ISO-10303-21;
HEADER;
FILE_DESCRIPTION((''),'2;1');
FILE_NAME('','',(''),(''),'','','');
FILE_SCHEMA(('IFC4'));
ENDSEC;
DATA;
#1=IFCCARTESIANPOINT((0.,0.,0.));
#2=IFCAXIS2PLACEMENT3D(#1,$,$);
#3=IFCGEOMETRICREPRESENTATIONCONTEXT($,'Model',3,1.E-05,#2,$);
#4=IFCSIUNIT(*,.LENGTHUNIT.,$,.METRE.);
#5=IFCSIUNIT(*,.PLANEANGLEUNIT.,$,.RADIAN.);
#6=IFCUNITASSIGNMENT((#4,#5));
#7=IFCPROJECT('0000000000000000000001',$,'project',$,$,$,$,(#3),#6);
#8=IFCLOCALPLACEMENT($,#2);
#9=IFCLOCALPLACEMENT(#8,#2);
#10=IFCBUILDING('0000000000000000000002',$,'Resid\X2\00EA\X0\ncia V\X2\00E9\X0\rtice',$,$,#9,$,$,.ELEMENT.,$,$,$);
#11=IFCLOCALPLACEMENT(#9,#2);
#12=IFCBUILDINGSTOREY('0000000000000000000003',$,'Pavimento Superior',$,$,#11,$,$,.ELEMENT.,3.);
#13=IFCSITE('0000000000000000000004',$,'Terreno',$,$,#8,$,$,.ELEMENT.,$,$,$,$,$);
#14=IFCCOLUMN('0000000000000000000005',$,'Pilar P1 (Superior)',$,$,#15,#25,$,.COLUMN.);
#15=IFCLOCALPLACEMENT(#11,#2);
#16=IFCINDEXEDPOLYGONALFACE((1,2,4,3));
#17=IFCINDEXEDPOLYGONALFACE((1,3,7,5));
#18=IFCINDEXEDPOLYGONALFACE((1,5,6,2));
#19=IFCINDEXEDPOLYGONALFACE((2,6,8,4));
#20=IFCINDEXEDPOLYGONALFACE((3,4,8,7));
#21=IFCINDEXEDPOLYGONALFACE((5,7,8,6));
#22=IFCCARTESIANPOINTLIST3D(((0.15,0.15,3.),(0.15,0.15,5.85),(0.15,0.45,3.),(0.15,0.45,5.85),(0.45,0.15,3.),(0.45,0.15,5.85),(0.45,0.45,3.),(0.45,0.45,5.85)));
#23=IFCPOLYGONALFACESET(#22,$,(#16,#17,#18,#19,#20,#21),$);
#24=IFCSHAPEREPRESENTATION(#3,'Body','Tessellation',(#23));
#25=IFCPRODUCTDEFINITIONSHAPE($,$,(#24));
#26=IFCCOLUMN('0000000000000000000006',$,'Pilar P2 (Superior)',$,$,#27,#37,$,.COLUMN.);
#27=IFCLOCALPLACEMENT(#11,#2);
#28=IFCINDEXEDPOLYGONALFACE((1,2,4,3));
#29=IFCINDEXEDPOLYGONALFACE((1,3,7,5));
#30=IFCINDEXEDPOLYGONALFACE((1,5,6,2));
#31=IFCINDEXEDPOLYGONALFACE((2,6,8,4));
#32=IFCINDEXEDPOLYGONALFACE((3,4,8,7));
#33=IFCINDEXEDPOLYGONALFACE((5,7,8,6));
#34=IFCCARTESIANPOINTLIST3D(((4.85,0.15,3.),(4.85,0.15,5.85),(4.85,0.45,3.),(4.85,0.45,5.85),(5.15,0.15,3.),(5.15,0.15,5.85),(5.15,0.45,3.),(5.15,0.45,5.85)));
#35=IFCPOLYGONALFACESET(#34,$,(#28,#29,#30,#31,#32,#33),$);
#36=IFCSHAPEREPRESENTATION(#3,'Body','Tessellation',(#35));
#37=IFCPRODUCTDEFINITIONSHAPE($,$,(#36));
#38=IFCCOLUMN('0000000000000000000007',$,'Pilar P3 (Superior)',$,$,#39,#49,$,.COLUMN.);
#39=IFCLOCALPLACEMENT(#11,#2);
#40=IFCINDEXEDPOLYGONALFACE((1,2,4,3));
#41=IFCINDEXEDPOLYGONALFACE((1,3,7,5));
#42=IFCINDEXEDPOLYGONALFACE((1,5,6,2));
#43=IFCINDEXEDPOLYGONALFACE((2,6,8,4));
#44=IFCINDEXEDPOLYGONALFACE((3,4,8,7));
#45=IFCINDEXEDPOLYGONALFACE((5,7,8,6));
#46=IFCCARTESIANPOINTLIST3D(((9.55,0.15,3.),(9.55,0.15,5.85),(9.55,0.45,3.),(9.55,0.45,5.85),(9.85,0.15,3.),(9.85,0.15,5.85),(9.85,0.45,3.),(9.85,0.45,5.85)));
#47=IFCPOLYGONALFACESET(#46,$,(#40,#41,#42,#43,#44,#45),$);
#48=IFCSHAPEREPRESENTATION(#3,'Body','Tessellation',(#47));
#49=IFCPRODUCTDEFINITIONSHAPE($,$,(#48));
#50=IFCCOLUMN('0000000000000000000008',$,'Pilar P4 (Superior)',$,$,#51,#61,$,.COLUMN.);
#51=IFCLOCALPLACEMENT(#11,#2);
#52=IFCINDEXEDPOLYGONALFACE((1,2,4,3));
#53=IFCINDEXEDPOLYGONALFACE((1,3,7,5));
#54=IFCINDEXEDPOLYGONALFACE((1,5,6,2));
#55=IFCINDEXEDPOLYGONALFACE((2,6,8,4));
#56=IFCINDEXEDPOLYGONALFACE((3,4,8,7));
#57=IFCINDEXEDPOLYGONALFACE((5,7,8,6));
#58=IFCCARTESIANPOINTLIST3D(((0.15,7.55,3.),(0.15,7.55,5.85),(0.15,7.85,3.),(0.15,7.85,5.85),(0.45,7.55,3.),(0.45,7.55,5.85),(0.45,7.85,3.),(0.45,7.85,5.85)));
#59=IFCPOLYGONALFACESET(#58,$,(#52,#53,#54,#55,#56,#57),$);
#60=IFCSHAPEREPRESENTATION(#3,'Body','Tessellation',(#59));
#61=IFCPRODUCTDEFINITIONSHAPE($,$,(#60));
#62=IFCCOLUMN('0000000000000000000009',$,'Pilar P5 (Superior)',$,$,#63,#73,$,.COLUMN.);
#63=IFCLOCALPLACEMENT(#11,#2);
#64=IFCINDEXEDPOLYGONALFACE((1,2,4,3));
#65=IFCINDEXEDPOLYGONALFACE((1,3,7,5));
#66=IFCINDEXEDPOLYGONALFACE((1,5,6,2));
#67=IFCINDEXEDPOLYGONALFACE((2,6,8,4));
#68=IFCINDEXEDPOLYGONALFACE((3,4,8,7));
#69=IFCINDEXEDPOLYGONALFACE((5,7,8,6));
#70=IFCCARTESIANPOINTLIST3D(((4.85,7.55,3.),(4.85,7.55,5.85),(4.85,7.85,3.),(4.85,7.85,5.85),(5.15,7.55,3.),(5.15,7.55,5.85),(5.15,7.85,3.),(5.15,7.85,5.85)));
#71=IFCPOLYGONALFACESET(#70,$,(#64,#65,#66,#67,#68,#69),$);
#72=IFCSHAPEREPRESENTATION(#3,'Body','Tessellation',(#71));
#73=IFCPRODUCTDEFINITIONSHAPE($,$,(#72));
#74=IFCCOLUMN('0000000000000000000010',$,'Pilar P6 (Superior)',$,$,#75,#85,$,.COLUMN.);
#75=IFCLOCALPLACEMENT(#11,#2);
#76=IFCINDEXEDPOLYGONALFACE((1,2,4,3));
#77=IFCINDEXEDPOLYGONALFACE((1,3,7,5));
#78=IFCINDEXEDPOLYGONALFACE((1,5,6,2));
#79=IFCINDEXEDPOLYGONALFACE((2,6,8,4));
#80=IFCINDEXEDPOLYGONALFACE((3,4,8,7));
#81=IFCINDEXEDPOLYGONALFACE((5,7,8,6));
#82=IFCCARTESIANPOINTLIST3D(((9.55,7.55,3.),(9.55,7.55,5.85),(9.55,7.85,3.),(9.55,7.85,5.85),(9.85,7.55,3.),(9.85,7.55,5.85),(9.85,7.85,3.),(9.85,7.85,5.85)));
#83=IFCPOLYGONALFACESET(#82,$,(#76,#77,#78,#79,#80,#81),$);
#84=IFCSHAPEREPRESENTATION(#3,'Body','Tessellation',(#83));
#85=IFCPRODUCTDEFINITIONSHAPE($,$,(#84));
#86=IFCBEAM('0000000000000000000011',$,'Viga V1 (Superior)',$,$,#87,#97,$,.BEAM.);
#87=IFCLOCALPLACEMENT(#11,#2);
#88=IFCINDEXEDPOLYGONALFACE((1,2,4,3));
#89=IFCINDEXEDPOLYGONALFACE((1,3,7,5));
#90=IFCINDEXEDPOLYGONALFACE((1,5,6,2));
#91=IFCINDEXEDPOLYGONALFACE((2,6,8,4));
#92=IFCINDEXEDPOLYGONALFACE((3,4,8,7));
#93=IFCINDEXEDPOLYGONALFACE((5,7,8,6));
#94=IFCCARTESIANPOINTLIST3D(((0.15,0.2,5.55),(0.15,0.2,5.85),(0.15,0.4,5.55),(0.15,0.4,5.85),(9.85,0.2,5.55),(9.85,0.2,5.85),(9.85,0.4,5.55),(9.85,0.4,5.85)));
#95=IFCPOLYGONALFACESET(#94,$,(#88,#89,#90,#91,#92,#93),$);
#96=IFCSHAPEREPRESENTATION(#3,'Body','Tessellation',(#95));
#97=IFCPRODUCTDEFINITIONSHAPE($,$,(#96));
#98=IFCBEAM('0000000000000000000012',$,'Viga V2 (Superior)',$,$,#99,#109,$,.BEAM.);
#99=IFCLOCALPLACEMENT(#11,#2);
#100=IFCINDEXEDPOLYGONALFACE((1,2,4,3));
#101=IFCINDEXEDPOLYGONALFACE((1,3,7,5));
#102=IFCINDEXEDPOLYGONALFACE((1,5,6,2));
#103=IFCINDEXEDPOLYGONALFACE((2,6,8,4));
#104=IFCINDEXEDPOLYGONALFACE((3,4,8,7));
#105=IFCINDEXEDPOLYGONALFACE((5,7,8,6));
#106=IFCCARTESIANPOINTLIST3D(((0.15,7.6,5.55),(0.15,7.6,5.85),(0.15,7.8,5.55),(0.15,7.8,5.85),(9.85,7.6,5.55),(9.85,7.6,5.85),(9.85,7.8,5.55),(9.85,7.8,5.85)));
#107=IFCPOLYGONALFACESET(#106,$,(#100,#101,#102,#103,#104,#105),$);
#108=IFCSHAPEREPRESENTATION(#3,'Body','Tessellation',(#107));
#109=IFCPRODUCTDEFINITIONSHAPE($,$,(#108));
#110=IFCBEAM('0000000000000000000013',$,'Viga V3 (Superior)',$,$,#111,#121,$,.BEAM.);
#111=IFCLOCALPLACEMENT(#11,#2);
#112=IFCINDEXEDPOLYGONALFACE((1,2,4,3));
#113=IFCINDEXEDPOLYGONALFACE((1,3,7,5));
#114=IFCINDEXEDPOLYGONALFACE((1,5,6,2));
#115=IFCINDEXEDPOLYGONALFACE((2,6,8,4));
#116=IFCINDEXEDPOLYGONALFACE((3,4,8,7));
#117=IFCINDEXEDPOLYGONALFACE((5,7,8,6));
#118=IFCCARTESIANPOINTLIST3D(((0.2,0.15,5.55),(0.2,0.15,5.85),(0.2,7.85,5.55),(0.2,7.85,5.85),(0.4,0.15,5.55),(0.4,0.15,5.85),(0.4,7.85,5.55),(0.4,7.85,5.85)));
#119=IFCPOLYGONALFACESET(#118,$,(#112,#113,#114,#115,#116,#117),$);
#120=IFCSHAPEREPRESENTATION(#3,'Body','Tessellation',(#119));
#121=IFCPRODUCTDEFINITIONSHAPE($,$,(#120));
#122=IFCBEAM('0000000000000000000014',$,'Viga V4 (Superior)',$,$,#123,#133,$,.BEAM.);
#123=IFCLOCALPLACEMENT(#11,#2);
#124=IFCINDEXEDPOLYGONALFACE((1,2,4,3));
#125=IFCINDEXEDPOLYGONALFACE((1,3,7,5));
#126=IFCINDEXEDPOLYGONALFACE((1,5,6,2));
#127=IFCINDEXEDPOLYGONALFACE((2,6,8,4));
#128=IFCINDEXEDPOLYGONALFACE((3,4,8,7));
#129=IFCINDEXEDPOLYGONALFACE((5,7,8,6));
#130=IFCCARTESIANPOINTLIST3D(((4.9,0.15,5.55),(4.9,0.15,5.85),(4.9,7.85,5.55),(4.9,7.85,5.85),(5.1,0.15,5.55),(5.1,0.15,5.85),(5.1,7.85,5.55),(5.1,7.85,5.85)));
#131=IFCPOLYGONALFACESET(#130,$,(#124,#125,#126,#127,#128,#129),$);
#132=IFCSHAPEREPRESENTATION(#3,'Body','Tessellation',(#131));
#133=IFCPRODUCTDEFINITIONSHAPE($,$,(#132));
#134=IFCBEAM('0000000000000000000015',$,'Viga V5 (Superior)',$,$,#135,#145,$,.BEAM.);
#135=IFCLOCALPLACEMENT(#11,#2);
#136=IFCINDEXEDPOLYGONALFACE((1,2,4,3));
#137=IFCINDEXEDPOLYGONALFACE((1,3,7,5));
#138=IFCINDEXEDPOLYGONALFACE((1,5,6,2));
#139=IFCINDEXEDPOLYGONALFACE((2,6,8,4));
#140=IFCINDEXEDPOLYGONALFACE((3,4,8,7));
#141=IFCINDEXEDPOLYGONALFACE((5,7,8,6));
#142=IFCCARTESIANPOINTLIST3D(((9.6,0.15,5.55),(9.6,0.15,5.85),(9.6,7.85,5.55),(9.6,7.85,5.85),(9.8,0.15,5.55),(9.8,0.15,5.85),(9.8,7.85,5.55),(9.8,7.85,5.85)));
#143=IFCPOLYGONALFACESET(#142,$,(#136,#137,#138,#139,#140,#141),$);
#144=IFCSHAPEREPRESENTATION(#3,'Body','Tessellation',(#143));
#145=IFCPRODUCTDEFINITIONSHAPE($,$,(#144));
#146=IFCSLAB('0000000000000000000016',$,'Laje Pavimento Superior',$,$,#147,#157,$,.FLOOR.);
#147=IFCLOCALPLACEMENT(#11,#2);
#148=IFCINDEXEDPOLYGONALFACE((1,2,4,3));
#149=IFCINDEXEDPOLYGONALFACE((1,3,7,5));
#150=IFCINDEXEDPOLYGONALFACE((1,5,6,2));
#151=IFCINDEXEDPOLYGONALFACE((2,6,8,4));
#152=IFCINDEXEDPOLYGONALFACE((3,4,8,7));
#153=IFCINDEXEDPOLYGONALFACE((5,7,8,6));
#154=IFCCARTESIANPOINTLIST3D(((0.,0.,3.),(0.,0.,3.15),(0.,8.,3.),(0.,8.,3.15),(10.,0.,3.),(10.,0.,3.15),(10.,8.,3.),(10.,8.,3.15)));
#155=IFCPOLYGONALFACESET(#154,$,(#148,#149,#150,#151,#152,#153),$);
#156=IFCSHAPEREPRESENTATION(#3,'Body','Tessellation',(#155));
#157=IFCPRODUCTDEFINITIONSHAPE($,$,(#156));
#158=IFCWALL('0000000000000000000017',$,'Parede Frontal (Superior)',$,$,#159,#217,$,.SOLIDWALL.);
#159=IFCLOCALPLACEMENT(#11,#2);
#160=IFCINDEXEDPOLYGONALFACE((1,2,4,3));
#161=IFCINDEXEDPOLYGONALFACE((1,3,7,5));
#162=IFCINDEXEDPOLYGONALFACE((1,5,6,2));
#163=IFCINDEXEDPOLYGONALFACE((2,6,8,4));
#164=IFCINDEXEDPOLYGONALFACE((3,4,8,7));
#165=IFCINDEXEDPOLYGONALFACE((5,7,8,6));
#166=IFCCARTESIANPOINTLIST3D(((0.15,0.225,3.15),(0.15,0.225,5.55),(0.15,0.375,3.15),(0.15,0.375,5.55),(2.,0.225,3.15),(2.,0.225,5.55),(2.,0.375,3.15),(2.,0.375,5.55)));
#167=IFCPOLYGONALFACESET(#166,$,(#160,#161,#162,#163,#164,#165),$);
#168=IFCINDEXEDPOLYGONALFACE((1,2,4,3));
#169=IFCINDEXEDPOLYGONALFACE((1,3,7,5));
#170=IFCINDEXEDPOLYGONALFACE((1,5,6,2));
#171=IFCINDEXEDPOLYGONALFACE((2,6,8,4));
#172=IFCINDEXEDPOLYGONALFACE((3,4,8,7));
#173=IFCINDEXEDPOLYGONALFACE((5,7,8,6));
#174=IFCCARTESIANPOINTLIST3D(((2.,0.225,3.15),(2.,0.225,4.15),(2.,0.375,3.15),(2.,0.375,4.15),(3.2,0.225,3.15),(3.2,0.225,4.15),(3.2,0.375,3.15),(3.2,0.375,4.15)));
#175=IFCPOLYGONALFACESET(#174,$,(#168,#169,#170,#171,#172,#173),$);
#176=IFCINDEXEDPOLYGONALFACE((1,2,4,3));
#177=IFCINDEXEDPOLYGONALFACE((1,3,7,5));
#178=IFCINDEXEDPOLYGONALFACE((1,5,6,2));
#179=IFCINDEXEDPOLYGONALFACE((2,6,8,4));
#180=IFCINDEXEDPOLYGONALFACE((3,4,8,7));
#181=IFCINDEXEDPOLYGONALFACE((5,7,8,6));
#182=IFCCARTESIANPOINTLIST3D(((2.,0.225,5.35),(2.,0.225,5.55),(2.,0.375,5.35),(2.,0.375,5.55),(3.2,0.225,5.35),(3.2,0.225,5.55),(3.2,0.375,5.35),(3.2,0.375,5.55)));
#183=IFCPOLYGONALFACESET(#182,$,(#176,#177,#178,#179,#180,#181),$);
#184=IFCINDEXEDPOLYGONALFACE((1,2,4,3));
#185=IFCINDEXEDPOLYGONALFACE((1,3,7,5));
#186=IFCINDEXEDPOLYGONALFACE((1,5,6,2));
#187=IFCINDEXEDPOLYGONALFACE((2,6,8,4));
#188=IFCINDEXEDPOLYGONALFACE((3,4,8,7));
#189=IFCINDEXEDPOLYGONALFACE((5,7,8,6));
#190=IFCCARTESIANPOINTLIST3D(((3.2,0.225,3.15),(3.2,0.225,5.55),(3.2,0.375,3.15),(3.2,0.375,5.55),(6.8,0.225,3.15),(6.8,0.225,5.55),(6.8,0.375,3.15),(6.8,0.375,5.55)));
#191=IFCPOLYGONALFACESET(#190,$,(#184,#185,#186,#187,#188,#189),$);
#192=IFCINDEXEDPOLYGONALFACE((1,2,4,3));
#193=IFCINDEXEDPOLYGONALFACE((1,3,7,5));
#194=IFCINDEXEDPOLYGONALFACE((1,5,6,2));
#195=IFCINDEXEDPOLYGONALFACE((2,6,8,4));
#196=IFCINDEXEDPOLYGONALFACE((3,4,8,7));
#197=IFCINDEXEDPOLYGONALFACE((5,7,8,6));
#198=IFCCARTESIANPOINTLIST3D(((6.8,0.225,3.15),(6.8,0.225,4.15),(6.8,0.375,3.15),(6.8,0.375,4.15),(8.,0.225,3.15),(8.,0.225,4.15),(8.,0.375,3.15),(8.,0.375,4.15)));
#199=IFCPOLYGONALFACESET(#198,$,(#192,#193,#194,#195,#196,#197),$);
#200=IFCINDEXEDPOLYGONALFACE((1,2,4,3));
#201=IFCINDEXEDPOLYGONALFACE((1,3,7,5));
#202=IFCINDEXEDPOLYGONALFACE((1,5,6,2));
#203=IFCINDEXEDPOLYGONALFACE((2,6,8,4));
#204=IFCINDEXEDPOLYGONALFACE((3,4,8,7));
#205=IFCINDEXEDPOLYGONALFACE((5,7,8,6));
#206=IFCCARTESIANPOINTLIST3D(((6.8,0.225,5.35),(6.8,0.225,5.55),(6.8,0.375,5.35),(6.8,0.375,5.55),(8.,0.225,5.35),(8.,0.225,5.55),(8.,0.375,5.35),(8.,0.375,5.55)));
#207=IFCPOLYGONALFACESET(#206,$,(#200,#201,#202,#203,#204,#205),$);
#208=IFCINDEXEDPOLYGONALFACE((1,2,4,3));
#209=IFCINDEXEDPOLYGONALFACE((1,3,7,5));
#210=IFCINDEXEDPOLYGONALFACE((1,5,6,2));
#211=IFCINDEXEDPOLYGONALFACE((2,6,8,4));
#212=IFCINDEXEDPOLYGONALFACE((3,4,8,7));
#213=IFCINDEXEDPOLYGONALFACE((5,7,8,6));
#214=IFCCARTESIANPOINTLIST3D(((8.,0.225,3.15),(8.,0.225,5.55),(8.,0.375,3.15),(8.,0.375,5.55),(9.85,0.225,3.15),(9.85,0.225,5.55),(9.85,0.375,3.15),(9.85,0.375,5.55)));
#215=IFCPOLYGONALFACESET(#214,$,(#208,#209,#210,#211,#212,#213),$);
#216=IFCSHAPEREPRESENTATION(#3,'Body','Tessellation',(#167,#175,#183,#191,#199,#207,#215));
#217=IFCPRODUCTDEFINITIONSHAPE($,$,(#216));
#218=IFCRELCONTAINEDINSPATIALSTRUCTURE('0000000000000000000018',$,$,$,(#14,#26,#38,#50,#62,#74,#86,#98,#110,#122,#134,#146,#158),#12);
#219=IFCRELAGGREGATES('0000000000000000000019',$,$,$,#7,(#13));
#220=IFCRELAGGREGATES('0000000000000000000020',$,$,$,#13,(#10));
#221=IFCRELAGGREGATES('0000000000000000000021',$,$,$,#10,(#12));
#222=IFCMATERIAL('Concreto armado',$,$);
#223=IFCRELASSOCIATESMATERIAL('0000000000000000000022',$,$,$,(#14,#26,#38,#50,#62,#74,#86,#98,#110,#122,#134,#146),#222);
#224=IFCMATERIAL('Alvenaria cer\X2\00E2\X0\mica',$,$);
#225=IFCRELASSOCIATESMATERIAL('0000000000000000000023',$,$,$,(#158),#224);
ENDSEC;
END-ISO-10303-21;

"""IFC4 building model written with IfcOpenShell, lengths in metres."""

from ifc_helpers import new_model, si_unit, frame, frame_2d, origin, place, context, project, spatial, rectangle, extrude, material, element, save


model = new_model("IFC4")

# Units and contexts
model_context = context("Model", 3, precision=1e-05, world=origin())
ifc_project = project(units=[si_unit("LENGTHUNIT", "METRE"), si_unit("PLANEANGLEUNIT", "RADIAN")], contexts=[model_context])

# Site, building, storey
site_placement = place(None, origin())
site = spatial("IfcSite", under=ifc_project, at=site_placement, Name="Terreno", CompositionType="ELEMENT")
building_placement = place(site_placement, origin())
building = spatial("IfcBuilding", under=site, at=building_placement, Name="Residência Vértice", CompositionType="ELEMENT")
storey_placement = place(building_placement, origin())
storey = spatial("IfcBuildingStorey", under=building, at=storey_placement, Name="Pavimento Superior", CompositionType="ELEMENT", Elevation=3.0)

# Columns
ifc_material_1 = material(Name="Concreto armado")
column_1_placement = place(storey_placement, origin())
element("IfcColumn", 1, at=column_1_placement, inside=storey, material=ifc_material_1, Name="Pilar P1 (Superior)", PredefinedType="COLUMN", context=model_context, shape_type="SweptSolid", body=[
    extrude(rectangle(XDim=0.3, YDim=0.3, at=frame_2d((0.3, 0.3))), frame((0.0, 0.0, 3.0)), (0.0, 0.0, 1.0), 2.85),
])
column_2_placement = place(storey_placement, origin())
element("IfcColumn", 2, at=column_2_placement, inside=storey, material=ifc_material_1, Name="Pilar P2 (Superior)", PredefinedType="COLUMN", context=model_context, shape_type="SweptSolid", body=[
    extrude(rectangle(XDim=0.3, YDim=0.3, at=frame_2d((5.0, 0.3))), frame((0.0, 0.0, 3.0)), (0.0, 0.0, 1.0), 2.85),
])
column_3_placement = place(storey_placement, origin())
element("IfcColumn", 3, at=column_3_placement, inside=storey, material=ifc_material_1, Name="Pilar P3 (Superior)", PredefinedType="COLUMN", context=model_context, shape_type="SweptSolid", body=[
    extrude(rectangle(XDim=0.3, YDim=0.3, at=frame_2d((9.7, 0.3))), frame((0.0, 0.0, 3.0)), (0.0, 0.0, 1.0), 2.85),
])
column_4_placement = place(storey_placement, origin())
element("IfcColumn", 4, at=column_4_placement, inside=storey, material=ifc_material_1, Name="Pilar P4 (Superior)", PredefinedType="COLUMN", context=model_context, shape_type="SweptSolid", body=[
    extrude(rectangle(XDim=0.3, YDim=0.3, at=frame_2d((0.3, 7.7))), frame((0.0, 0.0, 3.0)), (0.0, 0.0, 1.0), 2.85),
])
column_5_placement = place(storey_placement, origin())
element("IfcColumn", 5, at=column_5_placement, inside=storey, material=ifc_material_1, Name="Pilar P5 (Superior)", PredefinedType="COLUMN", context=model_context, shape_type="SweptSolid", body=[
    extrude(rectangle(XDim=0.3, YDim=0.3, at=frame_2d((5.0, 7.7))), frame((0.0, 0.0, 3.0)), (0.0, 0.0, 1.0), 2.85),
])
column_6_placement = place(storey_placement, origin())
element("IfcColumn", 6, at=column_6_placement, inside=storey, material=ifc_material_1, Name="Pilar P6 (Superior)", PredefinedType="COLUMN", context=model_context, shape_type="SweptSolid", body=[
    extrude(rectangle(XDim=0.3, YDim=0.3, at=frame_2d((9.7, 7.7))), frame((0.0, 0.0, 3.0)), (0.0, 0.0, 1.0), 2.85),
])

# Beams
beam_1_placement = place(storey_placement, origin())
element("IfcBeam", 7, at=beam_1_placement, inside=storey, material=ifc_material_1, Name="Viga V1 (Superior)", PredefinedType="BEAM", context=model_context, shape_type="SweptSolid", body=[
    extrude(rectangle(XDim=9.7, YDim=0.2, at=frame_2d((5.0, 0.3))), frame((0.0, 0.0, 5.55)), (0.0, 0.0, 1.0), 0.3),
])
beam_2_placement = place(storey_placement, origin())
element("IfcBeam", 8, at=beam_2_placement, inside=storey, material=ifc_material_1, Name="Viga V2 (Superior)", PredefinedType="BEAM", context=model_context, shape_type="SweptSolid", body=[
    extrude(rectangle(XDim=9.7, YDim=0.2, at=frame_2d((5.0, 7.7))), frame((0.0, 0.0, 5.55)), (0.0, 0.0, 1.0), 0.3),
])
beam_3_placement = place(storey_placement, origin())
element("IfcBeam", 9, at=beam_3_placement, inside=storey, material=ifc_material_1, Name="Viga V3 (Superior)", PredefinedType="BEAM", context=model_context, shape_type="SweptSolid", body=[
    extrude(rectangle(XDim=0.2, YDim=7.7, at=frame_2d((0.3, 4.0))), frame((0.0, 0.0, 5.55)), (0.0, 0.0, 1.0), 0.3),
])
beam_4_placement = place(storey_placement, origin())
element("IfcBeam", 10, at=beam_4_placement, inside=storey, material=ifc_material_1, Name="Viga V4 (Superior)", PredefinedType="BEAM", context=model_context, shape_type="SweptSolid", body=[
    extrude(rectangle(XDim=0.2, YDim=7.7, at=frame_2d((5.0, 4.0))), frame((0.0, 0.0, 5.55)), (0.0, 0.0, 1.0), 0.3),
])
beam_5_placement = place(storey_placement, origin())
element("IfcBeam", 11, at=beam_5_placement, inside=storey, material=ifc_material_1, Name="Viga V5 (Superior)", PredefinedType="BEAM", context=model_context, shape_type="SweptSolid", body=[
    extrude(rectangle(XDim=0.2, YDim=7.7, at=frame_2d((9.7, 4.0))), frame((0.0, 0.0, 5.55)), (0.0, 0.0, 1.0), 0.3),
])

# Slab
slab_placement = place(storey_placement, origin())
element("IfcSlab", 12, at=slab_placement, inside=storey, material=ifc_material_1, Name="Laje Pavimento Superior", PredefinedType="FLOOR", context=model_context, shape_type="SweptSolid", body=[
    extrude(rectangle(XDim=10.0, YDim=8.0, at=frame_2d((5.0, 4.0))), frame((0.0, 0.0, 3.0)), (0.0, 0.0, 1.0), 0.15),
])

# Wall
ifc_material_2 = material(Name="Alvenaria cerâmica")
wall_1_placement = place(storey_placement, origin())
element("IfcWall", 13, at=wall_1_placement, inside=storey, material=ifc_material_2, Name="Parede Frontal (Superior)", PredefinedType="SOLIDWALL", context=model_context, shape_type="SweptSolid", body=[
    extrude(rectangle(XDim=1.85, YDim=0.15, at=frame_2d((1.075, 0.3))), frame((0.0, 0.0, 3.15)), (0.0, 0.0, 1.0), 2.4),
    extrude(rectangle(XDim=1.2, YDim=0.15, at=frame_2d((2.6, 0.3))), frame((0.0, 0.0, 3.15)), (0.0, 0.0, 1.0), 1.0),
    extrude(rectangle(XDim=1.2, YDim=0.15, at=frame_2d((2.6, 0.3))), frame((0.0, 0.0, 5.35)), (0.0, 0.0, 1.0), 0.2),
    extrude(rectangle(XDim=3.6, YDim=0.15, at=frame_2d((5.0, 0.3))), frame((0.0, 0.0, 3.15)), (0.0, 0.0, 1.0), 2.4),
    extrude(rectangle(XDim=1.2, YDim=0.15, at=frame_2d((7.4, 0.3))), frame((0.0, 0.0, 3.15)), (0.0, 0.0, 1.0), 1.0),
    extrude(rectangle(XDim=1.2, YDim=0.15, at=frame_2d((7.4, 0.3))), frame((0.0, 0.0, 5.35)), (0.0, 0.0, 1.0), 0.2),
    extrude(rectangle(XDim=1.85, YDim=0.15, at=frame_2d((8.925, 0.3))), frame((0.0, 0.0, 3.15)), (0.0, 0.0, 1.0), 2.4),
])

save(model, "model.ifc")
